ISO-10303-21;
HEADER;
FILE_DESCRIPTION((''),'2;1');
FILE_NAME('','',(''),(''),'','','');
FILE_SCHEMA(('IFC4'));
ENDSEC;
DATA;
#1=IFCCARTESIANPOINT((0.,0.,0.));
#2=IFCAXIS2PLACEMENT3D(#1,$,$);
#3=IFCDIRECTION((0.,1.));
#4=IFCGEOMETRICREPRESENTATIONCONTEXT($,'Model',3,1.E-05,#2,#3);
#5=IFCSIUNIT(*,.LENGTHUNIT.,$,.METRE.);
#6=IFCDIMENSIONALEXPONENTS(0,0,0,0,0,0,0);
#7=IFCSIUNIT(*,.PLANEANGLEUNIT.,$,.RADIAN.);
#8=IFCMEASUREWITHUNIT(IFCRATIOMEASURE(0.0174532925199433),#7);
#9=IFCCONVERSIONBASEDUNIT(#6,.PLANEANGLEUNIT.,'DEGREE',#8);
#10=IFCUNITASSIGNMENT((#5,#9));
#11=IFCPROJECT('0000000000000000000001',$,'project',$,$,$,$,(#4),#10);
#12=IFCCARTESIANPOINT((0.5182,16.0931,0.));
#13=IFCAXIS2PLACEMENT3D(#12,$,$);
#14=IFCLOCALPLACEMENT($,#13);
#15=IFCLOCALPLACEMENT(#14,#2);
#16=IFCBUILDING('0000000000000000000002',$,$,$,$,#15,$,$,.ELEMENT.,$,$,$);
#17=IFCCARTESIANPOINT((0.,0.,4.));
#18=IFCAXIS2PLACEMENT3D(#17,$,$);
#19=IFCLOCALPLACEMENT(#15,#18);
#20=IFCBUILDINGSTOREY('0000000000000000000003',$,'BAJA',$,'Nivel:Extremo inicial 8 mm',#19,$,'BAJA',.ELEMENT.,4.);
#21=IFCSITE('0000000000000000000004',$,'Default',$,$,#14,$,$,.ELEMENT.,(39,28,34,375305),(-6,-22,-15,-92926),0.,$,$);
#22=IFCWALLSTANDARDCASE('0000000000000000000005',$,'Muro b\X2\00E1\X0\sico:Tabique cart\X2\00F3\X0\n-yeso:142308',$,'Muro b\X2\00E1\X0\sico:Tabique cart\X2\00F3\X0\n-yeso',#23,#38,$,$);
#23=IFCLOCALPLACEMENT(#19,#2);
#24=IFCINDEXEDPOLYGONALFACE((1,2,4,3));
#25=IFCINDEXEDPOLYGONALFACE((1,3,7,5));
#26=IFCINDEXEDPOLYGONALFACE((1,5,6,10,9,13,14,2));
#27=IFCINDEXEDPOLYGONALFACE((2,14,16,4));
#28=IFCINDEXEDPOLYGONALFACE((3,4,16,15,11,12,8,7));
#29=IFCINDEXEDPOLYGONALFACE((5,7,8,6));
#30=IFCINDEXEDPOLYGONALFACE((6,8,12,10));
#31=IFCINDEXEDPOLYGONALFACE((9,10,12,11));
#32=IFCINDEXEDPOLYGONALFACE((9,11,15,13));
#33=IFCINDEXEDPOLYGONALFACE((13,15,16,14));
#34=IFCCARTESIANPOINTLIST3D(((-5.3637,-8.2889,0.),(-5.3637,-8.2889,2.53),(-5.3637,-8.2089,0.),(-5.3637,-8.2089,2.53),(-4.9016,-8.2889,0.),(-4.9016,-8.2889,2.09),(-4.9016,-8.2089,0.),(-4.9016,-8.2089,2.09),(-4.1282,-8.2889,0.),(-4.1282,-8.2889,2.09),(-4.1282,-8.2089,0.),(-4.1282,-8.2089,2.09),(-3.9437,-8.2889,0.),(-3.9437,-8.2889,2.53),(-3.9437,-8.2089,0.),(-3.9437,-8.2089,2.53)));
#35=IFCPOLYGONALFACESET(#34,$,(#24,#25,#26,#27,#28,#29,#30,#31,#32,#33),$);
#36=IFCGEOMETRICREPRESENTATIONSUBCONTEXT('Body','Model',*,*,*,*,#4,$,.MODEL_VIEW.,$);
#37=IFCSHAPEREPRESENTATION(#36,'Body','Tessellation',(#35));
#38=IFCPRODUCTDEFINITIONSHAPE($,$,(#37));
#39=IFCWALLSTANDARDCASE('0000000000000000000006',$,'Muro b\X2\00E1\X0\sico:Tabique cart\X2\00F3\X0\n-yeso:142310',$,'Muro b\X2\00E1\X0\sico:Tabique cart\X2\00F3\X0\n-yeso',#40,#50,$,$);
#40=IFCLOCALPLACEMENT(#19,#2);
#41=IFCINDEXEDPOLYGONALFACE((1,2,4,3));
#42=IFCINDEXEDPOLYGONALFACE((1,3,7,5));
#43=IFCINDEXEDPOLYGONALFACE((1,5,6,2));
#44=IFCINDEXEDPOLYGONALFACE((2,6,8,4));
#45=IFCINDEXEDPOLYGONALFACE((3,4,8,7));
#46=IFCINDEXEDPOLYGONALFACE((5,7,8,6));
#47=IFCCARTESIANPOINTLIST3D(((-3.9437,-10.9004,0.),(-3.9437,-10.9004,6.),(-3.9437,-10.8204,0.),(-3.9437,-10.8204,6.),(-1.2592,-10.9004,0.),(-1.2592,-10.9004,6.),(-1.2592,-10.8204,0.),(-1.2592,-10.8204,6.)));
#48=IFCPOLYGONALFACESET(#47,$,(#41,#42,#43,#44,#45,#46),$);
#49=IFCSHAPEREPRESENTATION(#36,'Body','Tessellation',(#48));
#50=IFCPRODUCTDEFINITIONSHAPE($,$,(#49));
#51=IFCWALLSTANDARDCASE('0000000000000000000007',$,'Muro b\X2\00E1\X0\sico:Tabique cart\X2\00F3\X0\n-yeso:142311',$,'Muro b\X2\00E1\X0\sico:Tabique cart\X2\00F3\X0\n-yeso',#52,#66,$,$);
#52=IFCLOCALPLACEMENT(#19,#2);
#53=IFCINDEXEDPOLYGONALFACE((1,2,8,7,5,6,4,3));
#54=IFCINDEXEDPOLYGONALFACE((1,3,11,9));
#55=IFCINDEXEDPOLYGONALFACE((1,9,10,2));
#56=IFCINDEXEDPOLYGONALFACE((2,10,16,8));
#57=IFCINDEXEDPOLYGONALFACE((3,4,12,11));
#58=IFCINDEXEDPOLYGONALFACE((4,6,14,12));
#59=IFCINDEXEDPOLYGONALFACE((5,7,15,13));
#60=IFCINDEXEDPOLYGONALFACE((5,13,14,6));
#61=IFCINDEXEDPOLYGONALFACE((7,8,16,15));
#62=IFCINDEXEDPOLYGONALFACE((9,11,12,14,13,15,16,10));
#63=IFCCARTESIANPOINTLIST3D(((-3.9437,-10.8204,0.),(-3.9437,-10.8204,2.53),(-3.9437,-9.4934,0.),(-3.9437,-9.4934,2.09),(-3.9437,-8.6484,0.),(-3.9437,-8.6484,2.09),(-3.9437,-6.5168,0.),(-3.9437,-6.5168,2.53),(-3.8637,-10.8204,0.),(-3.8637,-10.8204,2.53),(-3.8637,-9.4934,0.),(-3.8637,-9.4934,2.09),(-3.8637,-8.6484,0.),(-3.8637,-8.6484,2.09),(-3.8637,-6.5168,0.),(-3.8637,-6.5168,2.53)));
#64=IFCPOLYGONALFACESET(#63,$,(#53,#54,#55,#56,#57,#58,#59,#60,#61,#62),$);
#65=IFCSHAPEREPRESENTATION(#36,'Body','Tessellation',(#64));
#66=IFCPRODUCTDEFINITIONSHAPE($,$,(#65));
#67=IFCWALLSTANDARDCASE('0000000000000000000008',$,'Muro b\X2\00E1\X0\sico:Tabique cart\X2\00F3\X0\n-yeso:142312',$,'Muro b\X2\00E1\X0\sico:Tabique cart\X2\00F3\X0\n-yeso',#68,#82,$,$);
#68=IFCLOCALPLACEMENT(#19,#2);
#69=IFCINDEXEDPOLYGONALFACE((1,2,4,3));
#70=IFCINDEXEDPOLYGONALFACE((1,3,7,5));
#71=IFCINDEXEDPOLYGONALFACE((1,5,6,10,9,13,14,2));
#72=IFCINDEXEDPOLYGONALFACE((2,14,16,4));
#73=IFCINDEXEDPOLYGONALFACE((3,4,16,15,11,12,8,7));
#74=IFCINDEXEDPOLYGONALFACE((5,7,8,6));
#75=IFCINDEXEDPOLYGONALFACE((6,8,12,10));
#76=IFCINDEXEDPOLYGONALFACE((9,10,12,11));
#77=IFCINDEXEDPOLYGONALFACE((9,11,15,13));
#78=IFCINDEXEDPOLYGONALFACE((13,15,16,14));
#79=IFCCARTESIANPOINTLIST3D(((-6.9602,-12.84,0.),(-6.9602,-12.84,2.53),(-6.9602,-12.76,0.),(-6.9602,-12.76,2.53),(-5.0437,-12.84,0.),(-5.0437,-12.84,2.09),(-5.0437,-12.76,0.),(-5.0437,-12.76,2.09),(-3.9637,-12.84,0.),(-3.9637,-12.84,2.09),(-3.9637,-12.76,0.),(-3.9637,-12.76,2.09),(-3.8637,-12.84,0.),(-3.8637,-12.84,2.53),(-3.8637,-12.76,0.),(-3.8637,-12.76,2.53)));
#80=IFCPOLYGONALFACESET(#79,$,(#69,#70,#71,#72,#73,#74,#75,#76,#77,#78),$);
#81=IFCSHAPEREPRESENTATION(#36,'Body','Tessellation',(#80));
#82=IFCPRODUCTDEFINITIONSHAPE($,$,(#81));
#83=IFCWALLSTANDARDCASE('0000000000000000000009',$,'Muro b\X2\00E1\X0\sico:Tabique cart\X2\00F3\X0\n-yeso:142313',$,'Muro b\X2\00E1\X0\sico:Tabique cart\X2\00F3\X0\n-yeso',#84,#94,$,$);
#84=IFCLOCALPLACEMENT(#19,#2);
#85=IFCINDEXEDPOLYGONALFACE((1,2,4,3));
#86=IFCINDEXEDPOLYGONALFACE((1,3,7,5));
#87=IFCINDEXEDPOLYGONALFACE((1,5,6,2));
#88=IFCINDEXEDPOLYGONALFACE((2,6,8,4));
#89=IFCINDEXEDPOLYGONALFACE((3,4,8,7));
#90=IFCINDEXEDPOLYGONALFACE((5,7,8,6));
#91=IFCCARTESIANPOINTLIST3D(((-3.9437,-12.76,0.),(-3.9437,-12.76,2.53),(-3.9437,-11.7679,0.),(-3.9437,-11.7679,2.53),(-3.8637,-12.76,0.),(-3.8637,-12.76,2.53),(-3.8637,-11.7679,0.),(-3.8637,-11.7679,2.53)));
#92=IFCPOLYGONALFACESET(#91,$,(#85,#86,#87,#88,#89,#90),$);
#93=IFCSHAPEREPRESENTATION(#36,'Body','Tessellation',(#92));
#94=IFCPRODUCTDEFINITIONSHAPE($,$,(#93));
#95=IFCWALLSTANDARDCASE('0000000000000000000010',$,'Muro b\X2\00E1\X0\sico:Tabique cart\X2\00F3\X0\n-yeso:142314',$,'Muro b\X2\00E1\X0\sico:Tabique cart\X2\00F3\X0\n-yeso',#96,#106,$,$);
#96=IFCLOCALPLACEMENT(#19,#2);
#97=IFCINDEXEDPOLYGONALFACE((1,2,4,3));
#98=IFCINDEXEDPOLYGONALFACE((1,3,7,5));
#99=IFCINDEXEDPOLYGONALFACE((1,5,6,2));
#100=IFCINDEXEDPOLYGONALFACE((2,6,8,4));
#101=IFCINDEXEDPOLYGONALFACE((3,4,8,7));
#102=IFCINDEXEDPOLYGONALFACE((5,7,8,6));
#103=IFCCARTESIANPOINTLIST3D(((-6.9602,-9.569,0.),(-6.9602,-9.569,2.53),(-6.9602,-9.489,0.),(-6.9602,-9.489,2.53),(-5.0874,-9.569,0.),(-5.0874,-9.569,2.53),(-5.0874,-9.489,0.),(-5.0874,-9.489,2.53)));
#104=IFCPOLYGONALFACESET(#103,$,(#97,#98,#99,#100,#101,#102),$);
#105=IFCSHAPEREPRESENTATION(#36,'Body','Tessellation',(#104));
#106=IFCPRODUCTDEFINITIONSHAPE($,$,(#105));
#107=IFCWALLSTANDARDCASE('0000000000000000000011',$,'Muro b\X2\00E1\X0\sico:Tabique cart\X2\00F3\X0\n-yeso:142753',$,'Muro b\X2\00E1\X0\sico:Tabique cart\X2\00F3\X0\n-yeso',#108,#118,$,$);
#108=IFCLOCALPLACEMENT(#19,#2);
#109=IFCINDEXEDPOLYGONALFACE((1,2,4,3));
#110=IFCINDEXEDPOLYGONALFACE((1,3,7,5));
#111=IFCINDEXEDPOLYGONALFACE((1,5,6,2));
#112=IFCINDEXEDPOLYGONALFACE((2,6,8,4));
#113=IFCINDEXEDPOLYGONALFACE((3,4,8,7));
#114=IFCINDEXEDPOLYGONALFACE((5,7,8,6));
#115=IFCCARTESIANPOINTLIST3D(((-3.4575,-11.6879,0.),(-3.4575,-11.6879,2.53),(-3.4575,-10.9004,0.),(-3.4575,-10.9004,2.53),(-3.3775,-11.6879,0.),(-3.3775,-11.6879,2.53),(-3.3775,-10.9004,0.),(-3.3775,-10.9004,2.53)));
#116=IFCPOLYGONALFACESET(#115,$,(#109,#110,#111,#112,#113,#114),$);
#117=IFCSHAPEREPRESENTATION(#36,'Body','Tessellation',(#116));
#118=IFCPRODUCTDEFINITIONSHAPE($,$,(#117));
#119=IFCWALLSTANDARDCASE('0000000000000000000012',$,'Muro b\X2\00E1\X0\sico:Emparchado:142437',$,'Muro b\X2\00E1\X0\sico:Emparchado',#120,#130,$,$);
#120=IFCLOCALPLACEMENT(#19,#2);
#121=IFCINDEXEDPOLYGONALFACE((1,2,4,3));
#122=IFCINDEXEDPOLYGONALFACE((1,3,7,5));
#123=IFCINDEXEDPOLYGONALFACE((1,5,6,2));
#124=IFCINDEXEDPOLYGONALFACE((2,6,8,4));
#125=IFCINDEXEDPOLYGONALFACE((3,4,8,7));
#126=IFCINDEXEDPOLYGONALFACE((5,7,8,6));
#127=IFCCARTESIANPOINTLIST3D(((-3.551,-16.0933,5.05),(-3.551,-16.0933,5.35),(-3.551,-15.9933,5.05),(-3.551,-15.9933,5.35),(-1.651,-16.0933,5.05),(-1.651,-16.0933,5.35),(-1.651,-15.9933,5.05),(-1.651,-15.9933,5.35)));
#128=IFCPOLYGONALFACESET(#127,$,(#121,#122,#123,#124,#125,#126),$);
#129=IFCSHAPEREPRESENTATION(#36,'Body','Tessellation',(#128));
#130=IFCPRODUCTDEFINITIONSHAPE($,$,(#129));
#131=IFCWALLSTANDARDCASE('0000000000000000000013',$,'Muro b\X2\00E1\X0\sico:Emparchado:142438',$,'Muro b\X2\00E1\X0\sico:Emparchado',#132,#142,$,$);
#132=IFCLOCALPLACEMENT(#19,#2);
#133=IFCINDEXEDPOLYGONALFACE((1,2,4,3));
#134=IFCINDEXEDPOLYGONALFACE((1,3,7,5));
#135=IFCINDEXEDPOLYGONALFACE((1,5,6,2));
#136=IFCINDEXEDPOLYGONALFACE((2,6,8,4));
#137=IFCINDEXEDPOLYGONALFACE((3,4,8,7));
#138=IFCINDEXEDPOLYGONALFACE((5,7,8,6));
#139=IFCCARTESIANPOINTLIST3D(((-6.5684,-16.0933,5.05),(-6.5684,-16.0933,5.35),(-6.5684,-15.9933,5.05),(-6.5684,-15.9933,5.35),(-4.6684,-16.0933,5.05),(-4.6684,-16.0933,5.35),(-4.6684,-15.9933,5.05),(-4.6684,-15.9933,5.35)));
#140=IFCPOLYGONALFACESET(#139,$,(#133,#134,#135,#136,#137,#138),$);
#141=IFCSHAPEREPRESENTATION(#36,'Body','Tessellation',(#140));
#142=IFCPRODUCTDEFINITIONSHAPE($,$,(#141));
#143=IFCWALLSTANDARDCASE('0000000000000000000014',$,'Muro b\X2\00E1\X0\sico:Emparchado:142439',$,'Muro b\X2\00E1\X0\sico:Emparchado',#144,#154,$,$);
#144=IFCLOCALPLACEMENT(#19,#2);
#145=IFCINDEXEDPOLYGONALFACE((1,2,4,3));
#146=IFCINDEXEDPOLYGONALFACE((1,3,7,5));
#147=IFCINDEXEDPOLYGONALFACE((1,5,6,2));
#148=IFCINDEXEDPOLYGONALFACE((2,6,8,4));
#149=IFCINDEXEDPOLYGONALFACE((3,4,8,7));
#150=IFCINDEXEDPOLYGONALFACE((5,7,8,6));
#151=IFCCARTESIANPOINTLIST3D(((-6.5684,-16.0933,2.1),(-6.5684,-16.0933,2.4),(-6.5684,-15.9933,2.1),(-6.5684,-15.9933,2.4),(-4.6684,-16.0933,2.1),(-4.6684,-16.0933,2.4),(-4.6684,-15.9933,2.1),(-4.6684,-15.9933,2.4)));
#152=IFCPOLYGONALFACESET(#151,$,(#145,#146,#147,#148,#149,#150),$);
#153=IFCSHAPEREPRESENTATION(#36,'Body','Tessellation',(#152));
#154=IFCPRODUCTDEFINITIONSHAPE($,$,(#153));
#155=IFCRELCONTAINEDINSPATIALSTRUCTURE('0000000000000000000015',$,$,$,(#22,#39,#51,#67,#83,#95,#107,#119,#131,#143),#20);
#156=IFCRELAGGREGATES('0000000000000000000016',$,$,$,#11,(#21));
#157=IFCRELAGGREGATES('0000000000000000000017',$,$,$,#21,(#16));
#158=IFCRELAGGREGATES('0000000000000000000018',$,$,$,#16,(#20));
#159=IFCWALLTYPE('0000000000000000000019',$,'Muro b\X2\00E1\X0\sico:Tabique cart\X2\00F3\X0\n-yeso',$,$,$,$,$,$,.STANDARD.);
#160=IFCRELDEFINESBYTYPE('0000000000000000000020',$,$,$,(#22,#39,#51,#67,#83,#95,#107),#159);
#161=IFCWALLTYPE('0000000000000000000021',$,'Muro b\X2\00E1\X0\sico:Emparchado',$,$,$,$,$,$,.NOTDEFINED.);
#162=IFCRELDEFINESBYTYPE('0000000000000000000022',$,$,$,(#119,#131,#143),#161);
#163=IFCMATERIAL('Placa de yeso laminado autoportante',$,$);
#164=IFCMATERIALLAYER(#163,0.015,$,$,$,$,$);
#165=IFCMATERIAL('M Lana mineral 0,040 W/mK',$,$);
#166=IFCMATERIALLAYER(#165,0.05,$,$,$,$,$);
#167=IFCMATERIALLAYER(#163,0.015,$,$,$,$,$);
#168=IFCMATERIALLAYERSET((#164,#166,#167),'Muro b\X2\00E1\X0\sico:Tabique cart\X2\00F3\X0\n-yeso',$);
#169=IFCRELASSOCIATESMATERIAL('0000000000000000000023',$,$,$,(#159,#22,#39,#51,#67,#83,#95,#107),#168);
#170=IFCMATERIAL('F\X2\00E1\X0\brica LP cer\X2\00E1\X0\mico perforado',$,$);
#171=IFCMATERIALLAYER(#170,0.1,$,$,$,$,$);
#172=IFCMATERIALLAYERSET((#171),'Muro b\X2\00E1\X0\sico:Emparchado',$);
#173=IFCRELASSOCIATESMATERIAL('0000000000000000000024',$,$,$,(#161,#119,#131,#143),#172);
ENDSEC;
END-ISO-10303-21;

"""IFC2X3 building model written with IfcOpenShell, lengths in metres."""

from ifc_helpers import new_model, entity, si_unit, converted_unit, direction, frame, frame_2d, origin, place, context, subcontext, project, spatial, polyline, rectangle, extrude, clip, bounded_halfspace, material, layer, layer_set, layer_usage, type_object, element, save


model = new_model("IFC2X3")

# Units and contexts
model_context = context("Model", 3, precision=1e-05, world=origin(), true_north=direction((0.0, 1.0)))
body_context = subcontext(model_context, "Body", "Model", "MODEL_VIEW")
ifc_project = project(units=[si_unit("LENGTHUNIT", "METRE"), converted_unit("PLANEANGLEUNIT", "DEGREE", entity("IfcRatioMeasure", 0.0174532925199433), si_unit("PLANEANGLEUNIT", "RADIAN"), dimensions=[0, 0, 0, 0, 0, 0, 0])], contexts=[model_context])

# Site, building, storey
site_placement = place(None, frame((0.5182, 16.0931, 0.0)))
site = spatial("IfcSite", under=ifc_project, at=site_placement, Name="Default", CompositionType="ELEMENT", RefLatitude=(39, 28, 34, 375305), RefLongitude=(-6, -22, -15, -92926), RefElevation=0.0)
building_placement = place(site_placement, origin())
building = spatial("IfcBuilding", under=site, at=building_placement, CompositionType="ELEMENT")
storey_placement = place(building_placement, frame((0.0, 0.0, 4.0)))
storey = spatial("IfcBuildingStorey", under=building, at=storey_placement, Name="BAJA", ObjectType="Nivel:Extremo inicial 8 mm", LongName="BAJA", CompositionType="ELEMENT", Elevation=4.0)

# Shared definitions
ifc_material_1 = material(Name="Placa de yeso laminado autoportante")

# Shared definitions
ifc_material_2 = material(Name="Fábrica LP cerámico perforado")
ifc_material_3 = material(Name="M Lana mineral 0,040 W/mK")

# Shared definitions
ifc_layer_1 = layer(ifc_material_1, 0.015)
ifc_layer_2 = layer(ifc_material_3, 0.05)
ifc_layer_3 = layer(ifc_material_1, 0.015)
ifc_layer_set_1 = layer_set([ifc_layer_1, ifc_layer_2, ifc_layer_3], Name="Muro básico:Tabique cartón-yeso")
wall_type_1 = type_object("IfcWallType", Name="Muro básico:Tabique cartón-yeso", PredefinedType="STANDARD", material=ifc_layer_set_1)

# Wall, opening
ifc_layer_usage_1 = layer_usage(ifc_layer_set_1, "AXIS2", "POSITIVE", -0.04)
wall_1_placement = place(storey_placement, frame((-5.3637, -8.2489, 0.0)))
wall_1 = element("IfcWallStandardCase", 1, at=wall_1_placement, inside=storey, type_object=wall_type_1, material=ifc_layer_usage_1, Name="Muro básico:Tabique cartón-yeso:142308", ObjectType="Muro básico:Tabique cartón-yeso", context=body_context, shape_type="Clipping", body=[
    clip(extrude(rectangle(XDim=1.42, YDim=0.08, at=frame_2d((0.71, 0.0), x_axis=(-1.0, 0.0))), origin(), (0.0, 0.0, 1.0), 2.53), bounded_halfspace(frame((0.0, -0.04, 2.53), z_axis=(0.0, 0.0, -1.0), x_axis=(0.0, -1.0, 0.0)), True, frame((0.0, -0.04, 2.53)), polyline([(0.0, 0.0), (1.42, 0.0), (1.42, 0.08), (0.0, 0.08), (0.0, 0.0)]))),
])
opening_1_placement = place(wall_1_placement, frame((5.3637, 8.2489, 0.0)))
element("IfcOpeningElement", 2, at=opening_1_placement, cuts=wall_1, ObjectType="Opening", context=body_context, shape_type="SweptSolid", body=[
    extrude(rectangle(XDim=2.09, YDim=0.7734, at=frame_2d((0.0, 0.0), x_axis=(1.0, 0.0))), frame((-4.5149, -8.4389, 1.045), z_axis=(0.0, 1.0, 0.0), x_axis=(0.0, 0.0, -1.0)), (0.0, 0.0, 1.0), 0.23),
])

# Wall
ifc_layer_usage_2 = layer_usage(ifc_layer_set_1, "AXIS2", "POSITIVE", -0.04)
wall_2_placement = place(storey_placement, frame((-3.9437, -10.8604, 0.0)))
element("IfcWallStandardCase", 3, at=wall_2_placement, inside=storey, type_object=wall_type_1, material=ifc_layer_usage_2, Name="Muro básico:Tabique cartón-yeso:142310", ObjectType="Muro básico:Tabique cartón-yeso", context=body_context, shape_type="SweptSolid", body=[
    extrude(rectangle(XDim=2.6845, YDim=0.08, at=frame_2d((1.3423, 0.0), x_axis=(-1.0, 0.0))), origin(), (0.0, 0.0, 1.0), 6.0),
])

# Walls, openings
ifc_layer_usage_3 = layer_usage(ifc_layer_set_1, "AXIS2", "POSITIVE", -0.04)
wall_3_placement = place(storey_placement, frame((-3.9037, -6.5168, 0.0), z_axis=(0.0, 0.0, 1.0), x_axis=(0.0, -1.0, 0.0)))
wall_3 = element("IfcWallStandardCase", 4, at=wall_3_placement, inside=storey, type_object=wall_type_1, material=ifc_layer_usage_3, Name="Muro básico:Tabique cartón-yeso:142311", ObjectType="Muro básico:Tabique cartón-yeso", context=body_context, shape_type="Clipping", body=[
    clip(extrude(rectangle(XDim=4.3036, YDim=0.08, at=frame_2d((2.1518, 0.0), x_axis=(-1.0, 0.0))), origin(), (0.0, 0.0, 1.0), 2.53), bounded_halfspace(frame((0.0, -0.04, 2.53), z_axis=(0.0, 0.0, -1.0), x_axis=(1.0, 0.0, 0.0)), True, frame((0.0, -0.04, 2.53)), polyline([(0.0, 0.0), (1.6921, 0.0), (1.7721, 0.0), (4.3036, 0.0), (4.3036, 0.08), (0.0, 0.08), (0.0, 0.0)]))),
])
opening_2_placement = place(wall_3_placement, frame((-6.5168, 3.9037, 0.0), z_axis=(0.0, 0.0, 1.0), x_axis=(0.0, 1.0, 0.0)))
element("IfcOpeningElement", 5, at=opening_2_placement, cuts=wall_3, ObjectType="Opening", context=body_context, shape_type="SweptSolid", body=[
    extrude(rectangle(XDim=2.09, YDim=0.845, at=frame_2d((0.0, 0.0), x_axis=(0.0, 1.0))), frame((-3.9437, -9.0709, 1.045), z_axis=(1.0, 0.0, 0.0), x_axis=(0.0, -1.0, 0.0)), (0.0, 0.0, 1.0), 0.08),
])
ifc_layer_usage_4 = layer_usage(ifc_layer_set_1, "AXIS2", "NEGATIVE", 0.04)
wall_4_placement = place(storey_placement, frame((-6.9602, -12.8, 0.0)))
wall_4 = element("IfcWallStandardCase", 6, at=wall_4_placement, inside=storey, type_object=wall_type_1, material=ifc_layer_usage_4, Name="Muro básico:Tabique cartón-yeso:142312", ObjectType="Muro básico:Tabique cartón-yeso", context=body_context, shape_type="Clipping", body=[
    clip(extrude(rectangle(XDim=3.0966, YDim=0.08, at=frame_2d((1.5483, 0.0), x_axis=(-1.0, 0.0))), origin(), (0.0, 0.0, 1.0), 2.53), bounded_halfspace(frame((0.0, -0.04, 2.53), z_axis=(0.0, 0.0, -1.0), x_axis=(0.0, -1.0, 0.0)), True, frame((0.0, -0.04, 2.53)), polyline([(0.0, 0.0), (0.0508, 0.0), (3.0966, 0.0), (3.0966, 0.08), (3.0166, 0.08), (0.0, 0.08), (0.0, 0.0102), (0.0, 0.0)]))),
])
opening_3_placement = place(wall_4_placement, frame((6.9602, 12.8, 0.0)))
element("IfcOpeningElement", 7, at=opening_3_placement, cuts=wall_4, ObjectType="Opening", context=body_context, shape_type="SweptSolid", body=[
    extrude(rectangle(XDim=2.09, YDim=1.08, at=frame_2d((0.0, 0.0), x_axis=(0.0, 1.0))), frame((-4.5037, -12.84, 1.045), z_axis=(0.0, 1.0, 0.0), x_axis=(1.0, 0.0, 0.0)), (0.0, 0.0, 1.0), 0.08),
])
ifc_layer_usage_5 = layer_usage(ifc_layer_set_1, "AXIS2", "NEGATIVE", 0.04)
wall_5_placement = place(storey_placement, frame((-3.9037, -12.76, 0.0), z_axis=(0.0, 0.0, 1.0), x_axis=(0.0, 1.0, 0.0)))
wall_5 = element("IfcWallStandardCase", 8, at=wall_5_placement, inside=storey, type_object=wall_type_1, material=ifc_layer_usage_5, Name="Muro básico:Tabique cartón-yeso:142313", ObjectType="Muro básico:Tabique cartón-yeso", context=body_context, shape_type="Clipping", body=[
    clip(extrude(rectangle(XDim=0.992, YDim=0.08, at=frame_2d((0.496, 0.0), x_axis=(-1.0, 0.0))), origin(), (0.0, 0.0, 1.0), 2.53), bounded_halfspace(frame((0.0, -0.04, 2.53), z_axis=(0.0, 0.0, -1.0), x_axis=(-1.0, 0.0, 0.0)), True, frame((0.0, -0.04, 2.53)), polyline([(0.0, 0.0), (0.992, 0.0), (0.992, 0.08), (0.0, 0.08), (0.0, 0.0)]))),
])
opening_4_placement = place(wall_5_placement, origin())
element("IfcOpeningElement", 9, at=opening_4_placement, cuts=wall_5, ObjectType="Opening", context=body_context, shape_type="SweptSolid", body=[
    extrude(rectangle(XDim=2.09, YDim=0.08, at=frame_2d((0.0, 0.0), x_axis=(1.0, 0.0))), frame((-0.04, 0.06, 1.045), z_axis=(0.0, 1.0, 0.0), x_axis=(0.0, 0.0, -1.0)), (0.0, 0.0, 1.0), 1.08),
])

# Wall
ifc_layer_usage_6 = layer_usage(ifc_layer_set_1, "AXIS2", "NEGATIVE", 0.04)
wall_6_placement = place(storey_placement, frame((-6.9602, -9.529, 0.0)))
element("IfcWallStandardCase", 10, at=wall_6_placement, inside=storey, type_object=wall_type_1, material=ifc_layer_usage_6, Name="Muro básico:Tabique cartón-yeso:142314", ObjectType="Muro básico:Tabique cartón-yeso", context=body_context, shape_type="Clipping", body=[
    clip(extrude(rectangle(XDim=1.8728, YDim=0.08, at=frame_2d((0.9364, 0.0), x_axis=(-1.0, 0.0))), origin(), (0.0, 0.0, 1.0), 2.53), bounded_halfspace(frame((0.0, -0.04, 2.53), z_axis=(0.0, 0.0, -1.0), x_axis=(0.0, -1.0, 0.0)), True, frame((0.0, -0.04, 2.53)), polyline([(0.0, 0.0), (1.8728, 0.0), (1.8728, 0.08), (0.0508, 0.08), (0.0, 0.08), (0.0, 0.0488), (0.0, 0.0)]))),
])

# Walls
ifc_layer_usage_7 = layer_usage(ifc_layer_set_1, "AXIS2", "POSITIVE", -0.04)
wall_7_placement = place(storey_placement, frame((-3.4175, -11.6879, 0.0), z_axis=(0.0, 0.0, 1.0), x_axis=(0.0, 1.0, 0.0)))
element("IfcWallStandardCase", 11, at=wall_7_placement, inside=storey, type_object=wall_type_1, material=ifc_layer_usage_7, Name="Muro básico:Tabique cartón-yeso:142753", ObjectType="Muro básico:Tabique cartón-yeso", context=body_context, shape_type="Clipping", body=[
    clip(extrude(rectangle(XDim=0.7875, YDim=0.08, at=frame_2d((0.3938, 0.0), x_axis=(-1.0, 0.0))), origin(), (0.0, 0.0, 1.0), 2.53), bounded_halfspace(frame((0.0, -0.04, 2.53), z_axis=(0.0, 0.0, -1.0), x_axis=(-1.0, 0.0, 0.0)), True, frame((0.0, -0.04, 2.53)), polyline([(0.0, 0.0), (0.7875, 0.0), (0.7875, 0.08), (0.0, 0.08), (0.0, 0.0)]))),
])
ifc_layer_4 = layer(ifc_material_2, 0.1)
ifc_layer_set_2 = layer_set([ifc_layer_4], Name="Muro básico:Emparchado")
ifc_layer_usage_8 = layer_usage(ifc_layer_set_2, "AXIS2", "NEGATIVE", 0.05)
wall_type_2 = type_object("IfcWallType", Name="Muro básico:Emparchado", PredefinedType="NOTDEFINED", material=ifc_layer_set_2)
wall_8_placement = place(storey_placement, frame((-3.551, -16.0433, 5.05)))
element("IfcWallStandardCase", 12, at=wall_8_placement, inside=storey, type_object=wall_type_2, material=ifc_layer_usage_8, Name="Muro básico:Emparchado:142437", ObjectType="Muro básico:Emparchado", context=body_context, shape_type="SweptSolid", body=[
    extrude(rectangle(XDim=1.9, YDim=0.1, at=frame_2d((0.95, 0.0), x_axis=(-1.0, 0.0))), origin(), (0.0, 0.0, 1.0), 0.3),
])
ifc_layer_usage_9 = layer_usage(ifc_layer_set_2, "AXIS2", "NEGATIVE", 0.05)
wall_9_placement = place(storey_placement, frame((-6.5684, -16.0433, 5.05)))
element("IfcWallStandardCase", 13, at=wall_9_placement, inside=storey, type_object=wall_type_2, material=ifc_layer_usage_9, Name="Muro básico:Emparchado:142438", ObjectType="Muro básico:Emparchado", context=body_context, shape_type="SweptSolid", body=[
    extrude(rectangle(XDim=1.9, YDim=0.1, at=frame_2d((0.95, 0.0), x_axis=(-1.0, 0.0))), origin(), (0.0, 0.0, 1.0), 0.3),
])
ifc_layer_usage_10 = layer_usage(ifc_layer_set_2, "AXIS2", "NEGATIVE", 0.05)
wall_10_placement = place(storey_placement, frame((-6.5684, -16.0433, 2.1)))
element("IfcWallStandardCase", 14, at=wall_10_placement, inside=storey, type_object=wall_type_2, material=ifc_layer_usage_10, Name="Muro básico:Emparchado:142439", ObjectType="Muro básico:Emparchado", context=body_context, shape_type="SweptSolid", body=[
    extrude(rectangle(XDim=1.9, YDim=0.1, at=frame_2d((0.95, 0.0), x_axis=(-1.0, 0.0))), origin(), (0.0, 0.0, 1.0), 0.3),
])

save(model, "model.ifc")
